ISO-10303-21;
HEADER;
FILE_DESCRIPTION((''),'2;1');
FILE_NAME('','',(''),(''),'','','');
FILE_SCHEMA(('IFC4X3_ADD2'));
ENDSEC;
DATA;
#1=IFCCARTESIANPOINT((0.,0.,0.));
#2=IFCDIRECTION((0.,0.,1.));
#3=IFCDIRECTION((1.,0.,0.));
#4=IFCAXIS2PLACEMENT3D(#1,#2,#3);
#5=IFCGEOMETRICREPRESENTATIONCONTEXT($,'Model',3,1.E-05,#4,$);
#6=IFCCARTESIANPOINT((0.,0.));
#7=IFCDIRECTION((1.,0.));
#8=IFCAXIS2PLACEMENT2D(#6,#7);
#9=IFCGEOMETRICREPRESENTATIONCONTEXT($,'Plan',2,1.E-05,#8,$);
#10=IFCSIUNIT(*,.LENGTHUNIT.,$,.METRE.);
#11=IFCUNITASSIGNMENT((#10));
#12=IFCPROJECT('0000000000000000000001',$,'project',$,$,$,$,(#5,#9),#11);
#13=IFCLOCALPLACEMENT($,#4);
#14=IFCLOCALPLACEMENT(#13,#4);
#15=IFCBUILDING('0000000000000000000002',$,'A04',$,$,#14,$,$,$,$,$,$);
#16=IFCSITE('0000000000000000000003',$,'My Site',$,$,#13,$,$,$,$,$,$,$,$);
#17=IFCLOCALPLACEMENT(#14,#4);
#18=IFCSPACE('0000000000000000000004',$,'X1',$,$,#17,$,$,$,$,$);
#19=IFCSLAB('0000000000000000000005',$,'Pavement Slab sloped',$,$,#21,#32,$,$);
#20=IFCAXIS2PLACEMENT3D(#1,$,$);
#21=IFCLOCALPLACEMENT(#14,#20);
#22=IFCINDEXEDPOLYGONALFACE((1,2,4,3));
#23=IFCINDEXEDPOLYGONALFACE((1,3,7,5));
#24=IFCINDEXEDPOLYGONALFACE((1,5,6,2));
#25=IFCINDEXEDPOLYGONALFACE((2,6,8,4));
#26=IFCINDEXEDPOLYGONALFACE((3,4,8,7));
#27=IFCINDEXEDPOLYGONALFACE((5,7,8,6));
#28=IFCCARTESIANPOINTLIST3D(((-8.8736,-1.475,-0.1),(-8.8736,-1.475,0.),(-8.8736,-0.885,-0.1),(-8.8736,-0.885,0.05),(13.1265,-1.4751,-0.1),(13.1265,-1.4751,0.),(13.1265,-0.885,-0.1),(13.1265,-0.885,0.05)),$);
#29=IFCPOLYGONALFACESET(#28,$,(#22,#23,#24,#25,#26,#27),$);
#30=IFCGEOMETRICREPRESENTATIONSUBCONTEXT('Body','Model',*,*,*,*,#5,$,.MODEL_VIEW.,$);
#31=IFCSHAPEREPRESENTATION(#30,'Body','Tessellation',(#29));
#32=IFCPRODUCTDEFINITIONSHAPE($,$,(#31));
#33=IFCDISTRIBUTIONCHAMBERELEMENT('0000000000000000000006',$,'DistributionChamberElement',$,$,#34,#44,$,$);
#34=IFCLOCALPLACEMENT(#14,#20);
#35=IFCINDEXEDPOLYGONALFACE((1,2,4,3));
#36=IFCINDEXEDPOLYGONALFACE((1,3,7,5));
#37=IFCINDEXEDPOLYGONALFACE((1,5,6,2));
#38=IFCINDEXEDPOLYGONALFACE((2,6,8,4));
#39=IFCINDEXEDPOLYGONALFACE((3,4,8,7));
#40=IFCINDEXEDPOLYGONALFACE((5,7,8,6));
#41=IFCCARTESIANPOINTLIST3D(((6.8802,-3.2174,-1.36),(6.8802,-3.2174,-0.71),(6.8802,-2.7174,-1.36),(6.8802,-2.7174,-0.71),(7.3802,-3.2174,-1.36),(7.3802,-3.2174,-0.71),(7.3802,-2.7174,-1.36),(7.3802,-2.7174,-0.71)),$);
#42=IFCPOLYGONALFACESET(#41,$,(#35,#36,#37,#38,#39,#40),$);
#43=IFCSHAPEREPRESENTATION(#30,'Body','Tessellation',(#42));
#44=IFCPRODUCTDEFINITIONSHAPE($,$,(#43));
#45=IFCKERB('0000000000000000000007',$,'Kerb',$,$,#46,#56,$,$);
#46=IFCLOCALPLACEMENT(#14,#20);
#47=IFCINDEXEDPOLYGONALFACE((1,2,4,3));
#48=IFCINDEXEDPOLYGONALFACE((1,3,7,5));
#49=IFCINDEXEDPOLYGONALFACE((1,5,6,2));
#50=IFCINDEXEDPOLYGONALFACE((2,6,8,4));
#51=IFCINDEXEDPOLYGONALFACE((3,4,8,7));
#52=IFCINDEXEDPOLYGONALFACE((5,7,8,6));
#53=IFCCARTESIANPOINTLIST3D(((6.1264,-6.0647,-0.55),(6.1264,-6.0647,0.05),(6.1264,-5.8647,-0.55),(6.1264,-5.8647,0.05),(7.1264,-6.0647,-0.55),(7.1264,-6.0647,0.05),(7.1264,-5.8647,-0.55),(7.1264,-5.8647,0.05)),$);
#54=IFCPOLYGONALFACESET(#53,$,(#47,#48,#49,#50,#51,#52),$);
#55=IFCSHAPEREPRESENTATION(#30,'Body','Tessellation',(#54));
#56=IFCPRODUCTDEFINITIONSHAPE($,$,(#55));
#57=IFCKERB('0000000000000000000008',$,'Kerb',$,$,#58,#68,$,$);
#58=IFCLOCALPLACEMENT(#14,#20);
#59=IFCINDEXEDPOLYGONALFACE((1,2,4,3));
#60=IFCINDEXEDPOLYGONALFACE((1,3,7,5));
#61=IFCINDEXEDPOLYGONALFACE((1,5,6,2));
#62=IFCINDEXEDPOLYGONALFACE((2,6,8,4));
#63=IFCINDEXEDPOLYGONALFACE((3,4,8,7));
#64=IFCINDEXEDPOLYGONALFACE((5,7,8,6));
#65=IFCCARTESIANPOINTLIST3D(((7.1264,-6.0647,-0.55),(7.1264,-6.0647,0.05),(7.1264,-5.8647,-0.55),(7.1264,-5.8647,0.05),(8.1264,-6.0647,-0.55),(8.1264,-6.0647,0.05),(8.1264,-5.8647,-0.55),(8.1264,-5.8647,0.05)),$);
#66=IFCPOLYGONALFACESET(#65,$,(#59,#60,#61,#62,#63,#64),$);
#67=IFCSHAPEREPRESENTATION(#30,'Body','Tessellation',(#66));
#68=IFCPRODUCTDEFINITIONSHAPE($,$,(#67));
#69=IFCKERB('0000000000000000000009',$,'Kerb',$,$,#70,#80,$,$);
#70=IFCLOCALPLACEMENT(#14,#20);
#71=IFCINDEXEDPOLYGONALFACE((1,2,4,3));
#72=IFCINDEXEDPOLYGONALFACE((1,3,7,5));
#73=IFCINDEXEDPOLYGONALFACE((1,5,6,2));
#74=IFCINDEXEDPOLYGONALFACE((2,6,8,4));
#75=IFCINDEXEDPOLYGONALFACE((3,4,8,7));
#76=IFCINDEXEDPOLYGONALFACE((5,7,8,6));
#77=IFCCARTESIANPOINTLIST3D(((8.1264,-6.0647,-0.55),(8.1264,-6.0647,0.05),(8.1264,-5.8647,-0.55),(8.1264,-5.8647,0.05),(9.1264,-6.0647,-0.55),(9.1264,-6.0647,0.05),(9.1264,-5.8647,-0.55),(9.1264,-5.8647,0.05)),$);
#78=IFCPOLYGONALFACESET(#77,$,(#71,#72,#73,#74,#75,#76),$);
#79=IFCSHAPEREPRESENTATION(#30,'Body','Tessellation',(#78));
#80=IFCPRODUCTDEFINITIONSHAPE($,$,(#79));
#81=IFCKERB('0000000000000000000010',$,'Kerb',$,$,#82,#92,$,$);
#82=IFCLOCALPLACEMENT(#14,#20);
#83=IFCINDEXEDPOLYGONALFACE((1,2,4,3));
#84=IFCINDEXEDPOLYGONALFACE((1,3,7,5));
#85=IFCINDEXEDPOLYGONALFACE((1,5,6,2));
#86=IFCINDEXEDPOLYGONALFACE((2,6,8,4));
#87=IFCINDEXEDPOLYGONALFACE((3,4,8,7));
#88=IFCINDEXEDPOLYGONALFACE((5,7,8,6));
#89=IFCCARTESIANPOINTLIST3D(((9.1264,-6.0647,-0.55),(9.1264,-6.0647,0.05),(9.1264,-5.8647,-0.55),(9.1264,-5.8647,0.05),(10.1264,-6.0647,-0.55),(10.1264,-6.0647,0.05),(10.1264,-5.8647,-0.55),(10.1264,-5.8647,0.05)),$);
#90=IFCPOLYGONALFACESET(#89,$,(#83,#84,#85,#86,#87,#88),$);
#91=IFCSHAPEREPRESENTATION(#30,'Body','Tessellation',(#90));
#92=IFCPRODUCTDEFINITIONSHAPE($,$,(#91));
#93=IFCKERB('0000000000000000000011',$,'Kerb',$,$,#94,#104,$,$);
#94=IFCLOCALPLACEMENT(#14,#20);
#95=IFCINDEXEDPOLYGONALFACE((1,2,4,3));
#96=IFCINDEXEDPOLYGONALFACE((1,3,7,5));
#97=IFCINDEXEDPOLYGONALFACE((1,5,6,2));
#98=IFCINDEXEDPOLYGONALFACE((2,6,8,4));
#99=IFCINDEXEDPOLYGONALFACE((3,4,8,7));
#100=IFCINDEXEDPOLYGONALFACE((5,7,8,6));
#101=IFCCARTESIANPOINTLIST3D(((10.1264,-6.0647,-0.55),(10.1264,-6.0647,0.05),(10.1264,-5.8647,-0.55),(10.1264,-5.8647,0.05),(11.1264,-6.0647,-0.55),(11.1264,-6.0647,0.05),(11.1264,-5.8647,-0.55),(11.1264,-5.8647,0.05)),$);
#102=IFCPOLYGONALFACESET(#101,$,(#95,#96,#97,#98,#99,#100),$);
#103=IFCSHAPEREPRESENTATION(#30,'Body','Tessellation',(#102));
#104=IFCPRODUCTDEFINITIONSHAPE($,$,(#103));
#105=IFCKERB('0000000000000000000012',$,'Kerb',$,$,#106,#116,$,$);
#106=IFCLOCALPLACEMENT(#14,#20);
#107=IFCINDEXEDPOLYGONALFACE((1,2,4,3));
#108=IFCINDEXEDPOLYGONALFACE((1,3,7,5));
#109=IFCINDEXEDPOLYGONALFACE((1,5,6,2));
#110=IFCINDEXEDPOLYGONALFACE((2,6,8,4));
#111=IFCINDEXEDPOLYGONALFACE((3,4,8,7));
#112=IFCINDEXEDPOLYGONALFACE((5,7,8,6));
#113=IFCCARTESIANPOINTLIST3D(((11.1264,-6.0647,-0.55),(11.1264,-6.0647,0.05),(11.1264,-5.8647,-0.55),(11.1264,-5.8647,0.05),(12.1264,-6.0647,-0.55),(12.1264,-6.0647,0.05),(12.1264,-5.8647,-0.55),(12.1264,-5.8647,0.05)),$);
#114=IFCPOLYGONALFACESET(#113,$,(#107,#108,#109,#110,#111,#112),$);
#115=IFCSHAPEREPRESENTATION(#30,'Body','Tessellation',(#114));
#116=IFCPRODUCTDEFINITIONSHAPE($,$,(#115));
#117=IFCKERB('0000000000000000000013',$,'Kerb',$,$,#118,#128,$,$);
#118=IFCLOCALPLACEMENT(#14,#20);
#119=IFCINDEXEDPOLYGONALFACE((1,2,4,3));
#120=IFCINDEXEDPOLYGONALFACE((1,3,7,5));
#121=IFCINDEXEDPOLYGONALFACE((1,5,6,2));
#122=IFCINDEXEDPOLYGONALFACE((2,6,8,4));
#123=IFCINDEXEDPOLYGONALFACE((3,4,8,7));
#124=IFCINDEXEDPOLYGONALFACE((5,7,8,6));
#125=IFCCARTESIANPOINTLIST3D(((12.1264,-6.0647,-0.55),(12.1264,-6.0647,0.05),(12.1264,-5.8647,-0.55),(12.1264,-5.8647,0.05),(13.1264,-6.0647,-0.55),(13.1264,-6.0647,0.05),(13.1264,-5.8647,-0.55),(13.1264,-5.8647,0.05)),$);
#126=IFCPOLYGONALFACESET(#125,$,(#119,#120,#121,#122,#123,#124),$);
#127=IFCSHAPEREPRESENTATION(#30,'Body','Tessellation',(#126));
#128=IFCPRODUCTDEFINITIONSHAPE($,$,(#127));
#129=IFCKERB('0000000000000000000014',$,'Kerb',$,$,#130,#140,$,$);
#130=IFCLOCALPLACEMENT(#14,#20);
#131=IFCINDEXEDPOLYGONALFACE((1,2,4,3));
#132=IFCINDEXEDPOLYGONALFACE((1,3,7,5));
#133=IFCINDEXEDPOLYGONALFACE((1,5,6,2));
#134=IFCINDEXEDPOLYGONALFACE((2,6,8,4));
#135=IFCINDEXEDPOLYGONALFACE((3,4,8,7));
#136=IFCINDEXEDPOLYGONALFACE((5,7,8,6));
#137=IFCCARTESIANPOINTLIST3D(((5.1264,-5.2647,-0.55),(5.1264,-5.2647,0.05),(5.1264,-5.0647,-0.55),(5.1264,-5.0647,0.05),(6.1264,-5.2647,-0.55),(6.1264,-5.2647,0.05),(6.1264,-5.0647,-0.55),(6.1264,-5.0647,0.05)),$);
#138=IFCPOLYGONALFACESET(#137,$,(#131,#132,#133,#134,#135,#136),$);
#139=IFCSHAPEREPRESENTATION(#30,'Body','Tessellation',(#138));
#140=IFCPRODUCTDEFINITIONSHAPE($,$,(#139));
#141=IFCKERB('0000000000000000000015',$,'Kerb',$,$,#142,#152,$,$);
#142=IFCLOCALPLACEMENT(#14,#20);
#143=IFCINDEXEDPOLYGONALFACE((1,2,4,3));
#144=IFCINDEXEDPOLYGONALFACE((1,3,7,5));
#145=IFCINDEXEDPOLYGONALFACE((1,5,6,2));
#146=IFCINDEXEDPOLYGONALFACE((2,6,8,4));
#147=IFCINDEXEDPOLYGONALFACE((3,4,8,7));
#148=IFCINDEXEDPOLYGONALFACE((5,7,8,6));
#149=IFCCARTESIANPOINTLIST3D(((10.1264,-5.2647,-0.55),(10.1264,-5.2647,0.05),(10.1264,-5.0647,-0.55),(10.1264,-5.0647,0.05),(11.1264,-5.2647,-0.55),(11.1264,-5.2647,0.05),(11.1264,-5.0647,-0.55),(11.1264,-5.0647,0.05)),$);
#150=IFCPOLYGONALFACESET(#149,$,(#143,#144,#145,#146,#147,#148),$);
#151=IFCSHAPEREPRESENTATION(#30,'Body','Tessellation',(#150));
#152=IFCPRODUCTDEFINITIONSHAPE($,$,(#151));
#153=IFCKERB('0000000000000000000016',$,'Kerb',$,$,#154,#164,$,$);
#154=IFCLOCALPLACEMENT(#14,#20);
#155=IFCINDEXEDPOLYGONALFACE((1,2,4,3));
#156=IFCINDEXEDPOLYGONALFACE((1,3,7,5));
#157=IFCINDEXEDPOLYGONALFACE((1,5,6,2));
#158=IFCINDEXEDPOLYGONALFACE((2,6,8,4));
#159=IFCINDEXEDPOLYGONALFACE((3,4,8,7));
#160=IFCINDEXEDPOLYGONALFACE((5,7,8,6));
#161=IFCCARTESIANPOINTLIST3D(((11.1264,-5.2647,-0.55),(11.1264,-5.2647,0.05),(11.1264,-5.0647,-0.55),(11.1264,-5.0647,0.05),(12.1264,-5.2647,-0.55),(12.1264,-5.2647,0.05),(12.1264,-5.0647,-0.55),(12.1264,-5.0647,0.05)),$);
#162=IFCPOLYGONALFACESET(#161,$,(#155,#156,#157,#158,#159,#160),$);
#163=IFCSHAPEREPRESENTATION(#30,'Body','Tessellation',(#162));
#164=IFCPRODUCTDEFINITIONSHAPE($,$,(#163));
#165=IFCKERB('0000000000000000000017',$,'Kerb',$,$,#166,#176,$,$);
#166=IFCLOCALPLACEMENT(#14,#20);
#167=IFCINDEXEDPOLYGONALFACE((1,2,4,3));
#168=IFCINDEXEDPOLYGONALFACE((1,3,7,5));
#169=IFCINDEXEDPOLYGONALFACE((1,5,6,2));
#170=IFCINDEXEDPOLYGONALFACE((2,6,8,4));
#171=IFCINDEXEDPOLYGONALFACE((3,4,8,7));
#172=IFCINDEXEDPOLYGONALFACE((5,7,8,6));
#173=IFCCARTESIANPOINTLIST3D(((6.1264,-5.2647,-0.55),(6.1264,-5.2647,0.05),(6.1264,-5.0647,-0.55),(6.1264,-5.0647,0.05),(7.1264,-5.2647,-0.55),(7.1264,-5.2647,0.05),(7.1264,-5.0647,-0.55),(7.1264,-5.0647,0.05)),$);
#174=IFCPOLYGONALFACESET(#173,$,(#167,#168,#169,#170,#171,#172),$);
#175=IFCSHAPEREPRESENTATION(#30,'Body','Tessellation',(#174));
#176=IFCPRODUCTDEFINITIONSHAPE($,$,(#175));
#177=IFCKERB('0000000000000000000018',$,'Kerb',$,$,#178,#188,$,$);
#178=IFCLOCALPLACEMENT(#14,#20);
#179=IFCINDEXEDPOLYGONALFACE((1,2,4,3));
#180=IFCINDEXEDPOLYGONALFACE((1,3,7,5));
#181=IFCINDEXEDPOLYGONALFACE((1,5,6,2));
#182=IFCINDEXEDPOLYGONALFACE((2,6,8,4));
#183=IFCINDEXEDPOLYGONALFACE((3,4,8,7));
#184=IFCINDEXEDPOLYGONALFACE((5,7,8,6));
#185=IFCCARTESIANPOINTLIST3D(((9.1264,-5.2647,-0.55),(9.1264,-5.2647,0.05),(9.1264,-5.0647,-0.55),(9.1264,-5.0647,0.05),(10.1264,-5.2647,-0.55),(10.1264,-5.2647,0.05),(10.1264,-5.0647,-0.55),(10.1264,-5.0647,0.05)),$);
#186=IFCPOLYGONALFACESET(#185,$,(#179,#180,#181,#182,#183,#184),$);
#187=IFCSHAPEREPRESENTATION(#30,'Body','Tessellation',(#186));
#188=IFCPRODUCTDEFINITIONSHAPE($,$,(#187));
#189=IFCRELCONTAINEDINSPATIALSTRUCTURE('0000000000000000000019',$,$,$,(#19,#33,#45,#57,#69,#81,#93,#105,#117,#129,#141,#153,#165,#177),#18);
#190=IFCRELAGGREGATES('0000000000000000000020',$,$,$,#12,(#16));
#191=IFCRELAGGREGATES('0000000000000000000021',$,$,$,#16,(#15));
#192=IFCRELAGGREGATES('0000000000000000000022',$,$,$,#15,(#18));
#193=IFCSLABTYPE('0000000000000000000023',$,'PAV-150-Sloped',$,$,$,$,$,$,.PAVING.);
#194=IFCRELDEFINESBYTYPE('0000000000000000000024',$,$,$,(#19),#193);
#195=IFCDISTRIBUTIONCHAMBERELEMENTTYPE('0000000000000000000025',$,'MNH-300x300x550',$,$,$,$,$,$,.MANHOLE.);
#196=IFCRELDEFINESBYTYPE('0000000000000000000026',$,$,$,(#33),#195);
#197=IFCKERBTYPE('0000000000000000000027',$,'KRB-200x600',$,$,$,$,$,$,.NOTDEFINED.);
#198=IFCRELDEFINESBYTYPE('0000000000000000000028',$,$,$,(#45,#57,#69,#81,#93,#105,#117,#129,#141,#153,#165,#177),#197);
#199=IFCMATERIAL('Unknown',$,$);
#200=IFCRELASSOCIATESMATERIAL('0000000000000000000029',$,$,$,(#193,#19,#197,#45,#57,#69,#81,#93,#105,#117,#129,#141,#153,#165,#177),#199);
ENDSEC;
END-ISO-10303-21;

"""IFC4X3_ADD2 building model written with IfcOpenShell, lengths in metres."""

from ifc_helpers import new_model, si_unit, frame, origin_with_axes, origin_2d_with_axis, place, context, subcontext, project, spatial, indexed_curve, rectangle, outline, extrude, source, transform, mapped, material, material_profile, profile_set, profile_usage, type_object, type_shapes, element, save


model = new_model("IFC4X3_ADD2")

# Units and contexts
model_context = context("Model", 3, precision=1e-05, world=origin_with_axes())
plan_context = context("Plan", 2, precision=1e-05, world=origin_2d_with_axis())
body_context = subcontext(model_context, "Body", "Model", "MODEL_VIEW")
ifc_project = project(units=[si_unit("LENGTHUNIT", "METRE")], contexts=[model_context, plan_context])

# Site, building, space
site_placement = place(None, origin_with_axes())
site = spatial("IfcSite", under=ifc_project, at=site_placement, Name="My Site")
building_placement = place(site_placement, origin_with_axes())
building = spatial("IfcBuilding", under=site, at=building_placement, Name="A04")
space_placement = place(building_placement, origin_with_axes())
space = spatial("IfcSpace", under=building, at=space_placement, Name="X1")

# Slab
ifc_material = material(Name="Unknown")
ifc_material_profile_1 = material_profile(ifc_material, outline(indexed_curve([(0.59, 0.1), (0.59, 0.0), (0.0, 0.0), (0.0, 0.15), (0.59, 0.1)])))
ifc_profile_set_1 = profile_set([ifc_material_profile_1])
ifc_profile_usage_1 = profile_usage(ifc_profile_set_1, cardinal=5)
slab_type = type_object("IfcSlabType", Name="PAV-150-Sloped", PredefinedType="PAVING", material=ifc_profile_set_1)
slab_placement = place(space_placement, frame((13.1265, -0.885, -0.1), z_axis=(-1.0, 0.000002, 0.000001), x_axis=(-0.000002, -1.0, 0.0)))
element("IfcSlab", 1, at=slab_placement, inside=space, type_object=slab_type, material=ifc_profile_usage_1, Name="Pavement Slab sloped", context=body_context, shape_type="SweptSolid", body=[
    extrude(outline(indexed_curve([(0.59, 0.1), (0.59, 0.0), (0.0, 0.0), (0.0, 0.15), (0.59, 0.1)])), origin_with_axes(), (0.0, 0.0, 1.0), 22.0),
])

# Distribution chamber element
distribution_chamber_element_type = type_object("IfcDistributionChamberElementType", Name="MNH-300x300x550", PredefinedType="MANHOLE")
shared_shape = source(origin_with_axes(), body_context, "Body", "SweptSolid", [
    extrude(outline(indexed_curve([(0.0, 0.0), (0.5, 0.0), (0.5, 0.5), (0.0, 0.5), (0.0, 0.0)])), origin_with_axes(), (0.0, 0.0, 1.0), 0.65),
])
type_shapes(distribution_chamber_element_type, [shared_shape])
distribution_chamber_element_placement = place(space_placement, frame((6.8802, -3.2174, -1.36), z_axis=(0.0, 0.0, 1.0), x_axis=(1.0, 0.0, 0.0)))
element("IfcDistributionChamberElement", 2, at=distribution_chamber_element_placement, inside=space, type_object=distribution_chamber_element_type, Name="DistributionChamberElement", context=body_context, shape_type="MappedRepresentation", body=[
    mapped(shared_shape, transform((0.0, 0.0, 0.0), x_axis=(1.0, 0.0, 0.0), y_axis=(0.0, 1.0, 0.0), z_axis=(0.0, 0.0, 1.0), scale=1.0)),
])

# Kerbs
ifc_material_profile_2 = material_profile(ifc_material, rectangle(XDim=0.2, YDim=0.6))
ifc_profile_set_2 = profile_set([ifc_material_profile_2])
ifc_profile_usage_2 = profile_usage(ifc_profile_set_2, cardinal=2)
kerb_type = type_object("IfcKerbType", Name="KRB-200x600", PredefinedType="NOTDEFINED", material=ifc_profile_set_2)
kerb_1_placement = place(space_placement, frame((6.1264, -5.9647, -0.55), z_axis=(1.0, 0.0, 0.0), x_axis=(0.0, 1.0, 0.0)))
element("IfcKerb", 3, at=kerb_1_placement, inside=space, type_object=kerb_type, material=ifc_profile_usage_2, Name="Kerb", context=body_context, shape_type="SweptSolid", body=[
    extrude(rectangle(XDim=0.2, YDim=0.6), frame((0.0, 0.3, 0.0), z_axis=(0.0, 0.0, 1.0), x_axis=(1.0, 0.0, 0.0)), (0.0, 0.0, 1.0), 1.0),
])
ifc_profile_usage_3 = profile_usage(ifc_profile_set_2, cardinal=2)
kerb_2_placement = place(space_placement, frame((7.1264, -5.9647, -0.55), z_axis=(1.0, 0.0, 0.0), x_axis=(0.0, 1.0, 0.0)))
element("IfcKerb", 4, at=kerb_2_placement, inside=space, type_object=kerb_type, material=ifc_profile_usage_3, Name="Kerb", context=body_context, shape_type="SweptSolid", body=[
    extrude(rectangle(XDim=0.2, YDim=0.6), frame((0.0, 0.3, 0.0), z_axis=(0.0, 0.0, 1.0), x_axis=(1.0, 0.0, 0.0)), (0.0, 0.0, 1.0), 1.0),
])
ifc_profile_usage_4 = profile_usage(ifc_profile_set_2, cardinal=2)
kerb_3_placement = place(space_placement, frame((8.1264, -5.9647, -0.55), z_axis=(1.0, 0.0, 0.0), x_axis=(0.0, 1.0, 0.0)))
element("IfcKerb", 5, at=kerb_3_placement, inside=space, type_object=kerb_type, material=ifc_profile_usage_4, Name="Kerb", context=body_context, shape_type="SweptSolid", body=[
    extrude(rectangle(XDim=0.2, YDim=0.6), frame((0.0, 0.3, 0.0), z_axis=(0.0, 0.0, 1.0), x_axis=(1.0, 0.0, 0.0)), (0.0, 0.0, 1.0), 1.0),
])
ifc_profile_usage_5 = profile_usage(ifc_profile_set_2, cardinal=2)
kerb_4_placement = place(space_placement, frame((9.1264, -5.9647, -0.55), z_axis=(1.0, 0.0, 0.0), x_axis=(0.0, 1.0, 0.0)))
element("IfcKerb", 6, at=kerb_4_placement, inside=space, type_object=kerb_type, material=ifc_profile_usage_5, Name="Kerb", context=body_context, shape_type="SweptSolid", body=[
    extrude(rectangle(XDim=0.2, YDim=0.6), frame((0.0, 0.3, 0.0), z_axis=(0.0, 0.0, 1.0), x_axis=(1.0, 0.0, 0.0)), (0.0, 0.0, 1.0), 1.0),
])
ifc_profile_usage_6 = profile_usage(ifc_profile_set_2, cardinal=2)
kerb_5_placement = place(space_placement, frame((10.1264, -5.9647, -0.55), z_axis=(1.0, 0.0, 0.0), x_axis=(0.0, 1.0, 0.0)))
element("IfcKerb", 7, at=kerb_5_placement, inside=space, type_object=kerb_type, material=ifc_profile_usage_6, Name="Kerb", context=body_context, shape_type="SweptSolid", body=[
    extrude(rectangle(XDim=0.2, YDim=0.6), frame((0.0, 0.3, 0.0), z_axis=(0.0, 0.0, 1.0), x_axis=(1.0, 0.0, 0.0)), (0.0, 0.0, 1.0), 1.0),
])
ifc_profile_usage_7 = profile_usage(ifc_profile_set_2, cardinal=2)
kerb_6_placement = place(space_placement, frame((11.1264, -5.9647, -0.55), z_axis=(1.0, 0.0, 0.0), x_axis=(0.0, 1.0, 0.0)))
element("IfcKerb", 8, at=kerb_6_placement, inside=space, type_object=kerb_type, material=ifc_profile_usage_7, Name="Kerb", context=body_context, shape_type="SweptSolid", body=[
    extrude(rectangle(XDim=0.2, YDim=0.6), frame((0.0, 0.3, 0.0), z_axis=(0.0, 0.0, 1.0), x_axis=(1.0, 0.0, 0.0)), (0.0, 0.0, 1.0), 1.0),
])
ifc_profile_usage_8 = profile_usage(ifc_profile_set_2, cardinal=2)
kerb_7_placement = place(space_placement, frame((12.1264, -5.9647, -0.55), z_axis=(1.0, 0.0, 0.0), x_axis=(0.0, 1.0, 0.0)))
element("IfcKerb", 9, at=kerb_7_placement, inside=space, type_object=kerb_type, material=ifc_profile_usage_8, Name="Kerb", context=body_context, shape_type="SweptSolid", body=[
    extrude(rectangle(XDim=0.2, YDim=0.6), frame((0.0, 0.3, 0.0), z_axis=(0.0, 0.0, 1.0), x_axis=(1.0, 0.0, 0.0)), (0.0, 0.0, 1.0), 1.0),
])
ifc_profile_usage_9 = profile_usage(ifc_profile_set_2, cardinal=2)
kerb_8_placement = place(space_placement, frame((5.1264, -5.1647, -0.55), z_axis=(1.0, 0.0, 0.0), x_axis=(0.0, 1.0, 0.0)))
element("IfcKerb", 10, at=kerb_8_placement, inside=space, type_object=kerb_type, material=ifc_profile_usage_9, Name="Kerb", context=body_context, shape_type="SweptSolid", body=[
    extrude(rectangle(XDim=0.2, YDim=0.6), frame((0.0, 0.3, 0.0), z_axis=(0.0, 0.0, 1.0), x_axis=(1.0, 0.0, 0.0)), (0.0, 0.0, 1.0), 1.0),
])
ifc_profile_usage_10 = profile_usage(ifc_profile_set_2, cardinal=2)
kerb_9_placement = place(space_placement, frame((10.1264, -5.1647, -0.55), z_axis=(1.0, 0.0, 0.0), x_axis=(0.0, 1.0, 0.0)))
element("IfcKerb", 11, at=kerb_9_placement, inside=space, type_object=kerb_type, material=ifc_profile_usage_10, Name="Kerb", context=body_context, shape_type="SweptSolid", body=[
    extrude(rectangle(XDim=0.2, YDim=0.6), frame((0.0, 0.3, 0.0), z_axis=(0.0, 0.0, 1.0), x_axis=(1.0, 0.0, 0.0)), (0.0, 0.0, 1.0), 1.0),
])
ifc_profile_usage_11 = profile_usage(ifc_profile_set_2, cardinal=2)
kerb_10_placement = place(space_placement, frame((11.1264, -5.1647, -0.55), z_axis=(1.0, 0.0, 0.0), x_axis=(0.0, 1.0, 0.0)))
element("IfcKerb", 12, at=kerb_10_placement, inside=space, type_object=kerb_type, material=ifc_profile_usage_11, Name="Kerb", context=body_context, shape_type="SweptSolid", body=[
    extrude(rectangle(XDim=0.2, YDim=0.6), frame((0.0, 0.3, 0.0), z_axis=(0.0, 0.0, 1.0), x_axis=(1.0, 0.0, 0.0)), (0.0, 0.0, 1.0), 1.0),
])
ifc_profile_usage_12 = profile_usage(ifc_profile_set_2, cardinal=2)
kerb_11_placement = place(space_placement, frame((6.1264, -5.1647, -0.55), z_axis=(1.0, 0.0, 0.0), x_axis=(0.0, 1.0, 0.0)))
element("IfcKerb", 13, at=kerb_11_placement, inside=space, type_object=kerb_type, material=ifc_profile_usage_12, Name="Kerb", context=body_context, shape_type="SweptSolid", body=[
    extrude(rectangle(XDim=0.2, YDim=0.6), frame((0.0, 0.3, 0.0), z_axis=(0.0, 0.0, 1.0), x_axis=(1.0, 0.0, 0.0)), (0.0, 0.0, 1.0), 1.0),
])
ifc_profile_usage_13 = profile_usage(ifc_profile_set_2, cardinal=2)
kerb_12_placement = place(space_placement, frame((9.1264, -5.1647, -0.55), z_axis=(1.0, 0.0, 0.0), x_axis=(0.0, 1.0, 0.0)))
element("IfcKerb", 14, at=kerb_12_placement, inside=space, type_object=kerb_type, material=ifc_profile_usage_13, Name="Kerb", context=body_context, shape_type="SweptSolid", body=[
    extrude(rectangle(XDim=0.2, YDim=0.6), frame((0.0, 0.3, 0.0), z_axis=(0.0, 0.0, 1.0), x_axis=(1.0, 0.0, 0.0)), (0.0, 0.0, 1.0), 1.0),
])

save(model, "model.ifc")
